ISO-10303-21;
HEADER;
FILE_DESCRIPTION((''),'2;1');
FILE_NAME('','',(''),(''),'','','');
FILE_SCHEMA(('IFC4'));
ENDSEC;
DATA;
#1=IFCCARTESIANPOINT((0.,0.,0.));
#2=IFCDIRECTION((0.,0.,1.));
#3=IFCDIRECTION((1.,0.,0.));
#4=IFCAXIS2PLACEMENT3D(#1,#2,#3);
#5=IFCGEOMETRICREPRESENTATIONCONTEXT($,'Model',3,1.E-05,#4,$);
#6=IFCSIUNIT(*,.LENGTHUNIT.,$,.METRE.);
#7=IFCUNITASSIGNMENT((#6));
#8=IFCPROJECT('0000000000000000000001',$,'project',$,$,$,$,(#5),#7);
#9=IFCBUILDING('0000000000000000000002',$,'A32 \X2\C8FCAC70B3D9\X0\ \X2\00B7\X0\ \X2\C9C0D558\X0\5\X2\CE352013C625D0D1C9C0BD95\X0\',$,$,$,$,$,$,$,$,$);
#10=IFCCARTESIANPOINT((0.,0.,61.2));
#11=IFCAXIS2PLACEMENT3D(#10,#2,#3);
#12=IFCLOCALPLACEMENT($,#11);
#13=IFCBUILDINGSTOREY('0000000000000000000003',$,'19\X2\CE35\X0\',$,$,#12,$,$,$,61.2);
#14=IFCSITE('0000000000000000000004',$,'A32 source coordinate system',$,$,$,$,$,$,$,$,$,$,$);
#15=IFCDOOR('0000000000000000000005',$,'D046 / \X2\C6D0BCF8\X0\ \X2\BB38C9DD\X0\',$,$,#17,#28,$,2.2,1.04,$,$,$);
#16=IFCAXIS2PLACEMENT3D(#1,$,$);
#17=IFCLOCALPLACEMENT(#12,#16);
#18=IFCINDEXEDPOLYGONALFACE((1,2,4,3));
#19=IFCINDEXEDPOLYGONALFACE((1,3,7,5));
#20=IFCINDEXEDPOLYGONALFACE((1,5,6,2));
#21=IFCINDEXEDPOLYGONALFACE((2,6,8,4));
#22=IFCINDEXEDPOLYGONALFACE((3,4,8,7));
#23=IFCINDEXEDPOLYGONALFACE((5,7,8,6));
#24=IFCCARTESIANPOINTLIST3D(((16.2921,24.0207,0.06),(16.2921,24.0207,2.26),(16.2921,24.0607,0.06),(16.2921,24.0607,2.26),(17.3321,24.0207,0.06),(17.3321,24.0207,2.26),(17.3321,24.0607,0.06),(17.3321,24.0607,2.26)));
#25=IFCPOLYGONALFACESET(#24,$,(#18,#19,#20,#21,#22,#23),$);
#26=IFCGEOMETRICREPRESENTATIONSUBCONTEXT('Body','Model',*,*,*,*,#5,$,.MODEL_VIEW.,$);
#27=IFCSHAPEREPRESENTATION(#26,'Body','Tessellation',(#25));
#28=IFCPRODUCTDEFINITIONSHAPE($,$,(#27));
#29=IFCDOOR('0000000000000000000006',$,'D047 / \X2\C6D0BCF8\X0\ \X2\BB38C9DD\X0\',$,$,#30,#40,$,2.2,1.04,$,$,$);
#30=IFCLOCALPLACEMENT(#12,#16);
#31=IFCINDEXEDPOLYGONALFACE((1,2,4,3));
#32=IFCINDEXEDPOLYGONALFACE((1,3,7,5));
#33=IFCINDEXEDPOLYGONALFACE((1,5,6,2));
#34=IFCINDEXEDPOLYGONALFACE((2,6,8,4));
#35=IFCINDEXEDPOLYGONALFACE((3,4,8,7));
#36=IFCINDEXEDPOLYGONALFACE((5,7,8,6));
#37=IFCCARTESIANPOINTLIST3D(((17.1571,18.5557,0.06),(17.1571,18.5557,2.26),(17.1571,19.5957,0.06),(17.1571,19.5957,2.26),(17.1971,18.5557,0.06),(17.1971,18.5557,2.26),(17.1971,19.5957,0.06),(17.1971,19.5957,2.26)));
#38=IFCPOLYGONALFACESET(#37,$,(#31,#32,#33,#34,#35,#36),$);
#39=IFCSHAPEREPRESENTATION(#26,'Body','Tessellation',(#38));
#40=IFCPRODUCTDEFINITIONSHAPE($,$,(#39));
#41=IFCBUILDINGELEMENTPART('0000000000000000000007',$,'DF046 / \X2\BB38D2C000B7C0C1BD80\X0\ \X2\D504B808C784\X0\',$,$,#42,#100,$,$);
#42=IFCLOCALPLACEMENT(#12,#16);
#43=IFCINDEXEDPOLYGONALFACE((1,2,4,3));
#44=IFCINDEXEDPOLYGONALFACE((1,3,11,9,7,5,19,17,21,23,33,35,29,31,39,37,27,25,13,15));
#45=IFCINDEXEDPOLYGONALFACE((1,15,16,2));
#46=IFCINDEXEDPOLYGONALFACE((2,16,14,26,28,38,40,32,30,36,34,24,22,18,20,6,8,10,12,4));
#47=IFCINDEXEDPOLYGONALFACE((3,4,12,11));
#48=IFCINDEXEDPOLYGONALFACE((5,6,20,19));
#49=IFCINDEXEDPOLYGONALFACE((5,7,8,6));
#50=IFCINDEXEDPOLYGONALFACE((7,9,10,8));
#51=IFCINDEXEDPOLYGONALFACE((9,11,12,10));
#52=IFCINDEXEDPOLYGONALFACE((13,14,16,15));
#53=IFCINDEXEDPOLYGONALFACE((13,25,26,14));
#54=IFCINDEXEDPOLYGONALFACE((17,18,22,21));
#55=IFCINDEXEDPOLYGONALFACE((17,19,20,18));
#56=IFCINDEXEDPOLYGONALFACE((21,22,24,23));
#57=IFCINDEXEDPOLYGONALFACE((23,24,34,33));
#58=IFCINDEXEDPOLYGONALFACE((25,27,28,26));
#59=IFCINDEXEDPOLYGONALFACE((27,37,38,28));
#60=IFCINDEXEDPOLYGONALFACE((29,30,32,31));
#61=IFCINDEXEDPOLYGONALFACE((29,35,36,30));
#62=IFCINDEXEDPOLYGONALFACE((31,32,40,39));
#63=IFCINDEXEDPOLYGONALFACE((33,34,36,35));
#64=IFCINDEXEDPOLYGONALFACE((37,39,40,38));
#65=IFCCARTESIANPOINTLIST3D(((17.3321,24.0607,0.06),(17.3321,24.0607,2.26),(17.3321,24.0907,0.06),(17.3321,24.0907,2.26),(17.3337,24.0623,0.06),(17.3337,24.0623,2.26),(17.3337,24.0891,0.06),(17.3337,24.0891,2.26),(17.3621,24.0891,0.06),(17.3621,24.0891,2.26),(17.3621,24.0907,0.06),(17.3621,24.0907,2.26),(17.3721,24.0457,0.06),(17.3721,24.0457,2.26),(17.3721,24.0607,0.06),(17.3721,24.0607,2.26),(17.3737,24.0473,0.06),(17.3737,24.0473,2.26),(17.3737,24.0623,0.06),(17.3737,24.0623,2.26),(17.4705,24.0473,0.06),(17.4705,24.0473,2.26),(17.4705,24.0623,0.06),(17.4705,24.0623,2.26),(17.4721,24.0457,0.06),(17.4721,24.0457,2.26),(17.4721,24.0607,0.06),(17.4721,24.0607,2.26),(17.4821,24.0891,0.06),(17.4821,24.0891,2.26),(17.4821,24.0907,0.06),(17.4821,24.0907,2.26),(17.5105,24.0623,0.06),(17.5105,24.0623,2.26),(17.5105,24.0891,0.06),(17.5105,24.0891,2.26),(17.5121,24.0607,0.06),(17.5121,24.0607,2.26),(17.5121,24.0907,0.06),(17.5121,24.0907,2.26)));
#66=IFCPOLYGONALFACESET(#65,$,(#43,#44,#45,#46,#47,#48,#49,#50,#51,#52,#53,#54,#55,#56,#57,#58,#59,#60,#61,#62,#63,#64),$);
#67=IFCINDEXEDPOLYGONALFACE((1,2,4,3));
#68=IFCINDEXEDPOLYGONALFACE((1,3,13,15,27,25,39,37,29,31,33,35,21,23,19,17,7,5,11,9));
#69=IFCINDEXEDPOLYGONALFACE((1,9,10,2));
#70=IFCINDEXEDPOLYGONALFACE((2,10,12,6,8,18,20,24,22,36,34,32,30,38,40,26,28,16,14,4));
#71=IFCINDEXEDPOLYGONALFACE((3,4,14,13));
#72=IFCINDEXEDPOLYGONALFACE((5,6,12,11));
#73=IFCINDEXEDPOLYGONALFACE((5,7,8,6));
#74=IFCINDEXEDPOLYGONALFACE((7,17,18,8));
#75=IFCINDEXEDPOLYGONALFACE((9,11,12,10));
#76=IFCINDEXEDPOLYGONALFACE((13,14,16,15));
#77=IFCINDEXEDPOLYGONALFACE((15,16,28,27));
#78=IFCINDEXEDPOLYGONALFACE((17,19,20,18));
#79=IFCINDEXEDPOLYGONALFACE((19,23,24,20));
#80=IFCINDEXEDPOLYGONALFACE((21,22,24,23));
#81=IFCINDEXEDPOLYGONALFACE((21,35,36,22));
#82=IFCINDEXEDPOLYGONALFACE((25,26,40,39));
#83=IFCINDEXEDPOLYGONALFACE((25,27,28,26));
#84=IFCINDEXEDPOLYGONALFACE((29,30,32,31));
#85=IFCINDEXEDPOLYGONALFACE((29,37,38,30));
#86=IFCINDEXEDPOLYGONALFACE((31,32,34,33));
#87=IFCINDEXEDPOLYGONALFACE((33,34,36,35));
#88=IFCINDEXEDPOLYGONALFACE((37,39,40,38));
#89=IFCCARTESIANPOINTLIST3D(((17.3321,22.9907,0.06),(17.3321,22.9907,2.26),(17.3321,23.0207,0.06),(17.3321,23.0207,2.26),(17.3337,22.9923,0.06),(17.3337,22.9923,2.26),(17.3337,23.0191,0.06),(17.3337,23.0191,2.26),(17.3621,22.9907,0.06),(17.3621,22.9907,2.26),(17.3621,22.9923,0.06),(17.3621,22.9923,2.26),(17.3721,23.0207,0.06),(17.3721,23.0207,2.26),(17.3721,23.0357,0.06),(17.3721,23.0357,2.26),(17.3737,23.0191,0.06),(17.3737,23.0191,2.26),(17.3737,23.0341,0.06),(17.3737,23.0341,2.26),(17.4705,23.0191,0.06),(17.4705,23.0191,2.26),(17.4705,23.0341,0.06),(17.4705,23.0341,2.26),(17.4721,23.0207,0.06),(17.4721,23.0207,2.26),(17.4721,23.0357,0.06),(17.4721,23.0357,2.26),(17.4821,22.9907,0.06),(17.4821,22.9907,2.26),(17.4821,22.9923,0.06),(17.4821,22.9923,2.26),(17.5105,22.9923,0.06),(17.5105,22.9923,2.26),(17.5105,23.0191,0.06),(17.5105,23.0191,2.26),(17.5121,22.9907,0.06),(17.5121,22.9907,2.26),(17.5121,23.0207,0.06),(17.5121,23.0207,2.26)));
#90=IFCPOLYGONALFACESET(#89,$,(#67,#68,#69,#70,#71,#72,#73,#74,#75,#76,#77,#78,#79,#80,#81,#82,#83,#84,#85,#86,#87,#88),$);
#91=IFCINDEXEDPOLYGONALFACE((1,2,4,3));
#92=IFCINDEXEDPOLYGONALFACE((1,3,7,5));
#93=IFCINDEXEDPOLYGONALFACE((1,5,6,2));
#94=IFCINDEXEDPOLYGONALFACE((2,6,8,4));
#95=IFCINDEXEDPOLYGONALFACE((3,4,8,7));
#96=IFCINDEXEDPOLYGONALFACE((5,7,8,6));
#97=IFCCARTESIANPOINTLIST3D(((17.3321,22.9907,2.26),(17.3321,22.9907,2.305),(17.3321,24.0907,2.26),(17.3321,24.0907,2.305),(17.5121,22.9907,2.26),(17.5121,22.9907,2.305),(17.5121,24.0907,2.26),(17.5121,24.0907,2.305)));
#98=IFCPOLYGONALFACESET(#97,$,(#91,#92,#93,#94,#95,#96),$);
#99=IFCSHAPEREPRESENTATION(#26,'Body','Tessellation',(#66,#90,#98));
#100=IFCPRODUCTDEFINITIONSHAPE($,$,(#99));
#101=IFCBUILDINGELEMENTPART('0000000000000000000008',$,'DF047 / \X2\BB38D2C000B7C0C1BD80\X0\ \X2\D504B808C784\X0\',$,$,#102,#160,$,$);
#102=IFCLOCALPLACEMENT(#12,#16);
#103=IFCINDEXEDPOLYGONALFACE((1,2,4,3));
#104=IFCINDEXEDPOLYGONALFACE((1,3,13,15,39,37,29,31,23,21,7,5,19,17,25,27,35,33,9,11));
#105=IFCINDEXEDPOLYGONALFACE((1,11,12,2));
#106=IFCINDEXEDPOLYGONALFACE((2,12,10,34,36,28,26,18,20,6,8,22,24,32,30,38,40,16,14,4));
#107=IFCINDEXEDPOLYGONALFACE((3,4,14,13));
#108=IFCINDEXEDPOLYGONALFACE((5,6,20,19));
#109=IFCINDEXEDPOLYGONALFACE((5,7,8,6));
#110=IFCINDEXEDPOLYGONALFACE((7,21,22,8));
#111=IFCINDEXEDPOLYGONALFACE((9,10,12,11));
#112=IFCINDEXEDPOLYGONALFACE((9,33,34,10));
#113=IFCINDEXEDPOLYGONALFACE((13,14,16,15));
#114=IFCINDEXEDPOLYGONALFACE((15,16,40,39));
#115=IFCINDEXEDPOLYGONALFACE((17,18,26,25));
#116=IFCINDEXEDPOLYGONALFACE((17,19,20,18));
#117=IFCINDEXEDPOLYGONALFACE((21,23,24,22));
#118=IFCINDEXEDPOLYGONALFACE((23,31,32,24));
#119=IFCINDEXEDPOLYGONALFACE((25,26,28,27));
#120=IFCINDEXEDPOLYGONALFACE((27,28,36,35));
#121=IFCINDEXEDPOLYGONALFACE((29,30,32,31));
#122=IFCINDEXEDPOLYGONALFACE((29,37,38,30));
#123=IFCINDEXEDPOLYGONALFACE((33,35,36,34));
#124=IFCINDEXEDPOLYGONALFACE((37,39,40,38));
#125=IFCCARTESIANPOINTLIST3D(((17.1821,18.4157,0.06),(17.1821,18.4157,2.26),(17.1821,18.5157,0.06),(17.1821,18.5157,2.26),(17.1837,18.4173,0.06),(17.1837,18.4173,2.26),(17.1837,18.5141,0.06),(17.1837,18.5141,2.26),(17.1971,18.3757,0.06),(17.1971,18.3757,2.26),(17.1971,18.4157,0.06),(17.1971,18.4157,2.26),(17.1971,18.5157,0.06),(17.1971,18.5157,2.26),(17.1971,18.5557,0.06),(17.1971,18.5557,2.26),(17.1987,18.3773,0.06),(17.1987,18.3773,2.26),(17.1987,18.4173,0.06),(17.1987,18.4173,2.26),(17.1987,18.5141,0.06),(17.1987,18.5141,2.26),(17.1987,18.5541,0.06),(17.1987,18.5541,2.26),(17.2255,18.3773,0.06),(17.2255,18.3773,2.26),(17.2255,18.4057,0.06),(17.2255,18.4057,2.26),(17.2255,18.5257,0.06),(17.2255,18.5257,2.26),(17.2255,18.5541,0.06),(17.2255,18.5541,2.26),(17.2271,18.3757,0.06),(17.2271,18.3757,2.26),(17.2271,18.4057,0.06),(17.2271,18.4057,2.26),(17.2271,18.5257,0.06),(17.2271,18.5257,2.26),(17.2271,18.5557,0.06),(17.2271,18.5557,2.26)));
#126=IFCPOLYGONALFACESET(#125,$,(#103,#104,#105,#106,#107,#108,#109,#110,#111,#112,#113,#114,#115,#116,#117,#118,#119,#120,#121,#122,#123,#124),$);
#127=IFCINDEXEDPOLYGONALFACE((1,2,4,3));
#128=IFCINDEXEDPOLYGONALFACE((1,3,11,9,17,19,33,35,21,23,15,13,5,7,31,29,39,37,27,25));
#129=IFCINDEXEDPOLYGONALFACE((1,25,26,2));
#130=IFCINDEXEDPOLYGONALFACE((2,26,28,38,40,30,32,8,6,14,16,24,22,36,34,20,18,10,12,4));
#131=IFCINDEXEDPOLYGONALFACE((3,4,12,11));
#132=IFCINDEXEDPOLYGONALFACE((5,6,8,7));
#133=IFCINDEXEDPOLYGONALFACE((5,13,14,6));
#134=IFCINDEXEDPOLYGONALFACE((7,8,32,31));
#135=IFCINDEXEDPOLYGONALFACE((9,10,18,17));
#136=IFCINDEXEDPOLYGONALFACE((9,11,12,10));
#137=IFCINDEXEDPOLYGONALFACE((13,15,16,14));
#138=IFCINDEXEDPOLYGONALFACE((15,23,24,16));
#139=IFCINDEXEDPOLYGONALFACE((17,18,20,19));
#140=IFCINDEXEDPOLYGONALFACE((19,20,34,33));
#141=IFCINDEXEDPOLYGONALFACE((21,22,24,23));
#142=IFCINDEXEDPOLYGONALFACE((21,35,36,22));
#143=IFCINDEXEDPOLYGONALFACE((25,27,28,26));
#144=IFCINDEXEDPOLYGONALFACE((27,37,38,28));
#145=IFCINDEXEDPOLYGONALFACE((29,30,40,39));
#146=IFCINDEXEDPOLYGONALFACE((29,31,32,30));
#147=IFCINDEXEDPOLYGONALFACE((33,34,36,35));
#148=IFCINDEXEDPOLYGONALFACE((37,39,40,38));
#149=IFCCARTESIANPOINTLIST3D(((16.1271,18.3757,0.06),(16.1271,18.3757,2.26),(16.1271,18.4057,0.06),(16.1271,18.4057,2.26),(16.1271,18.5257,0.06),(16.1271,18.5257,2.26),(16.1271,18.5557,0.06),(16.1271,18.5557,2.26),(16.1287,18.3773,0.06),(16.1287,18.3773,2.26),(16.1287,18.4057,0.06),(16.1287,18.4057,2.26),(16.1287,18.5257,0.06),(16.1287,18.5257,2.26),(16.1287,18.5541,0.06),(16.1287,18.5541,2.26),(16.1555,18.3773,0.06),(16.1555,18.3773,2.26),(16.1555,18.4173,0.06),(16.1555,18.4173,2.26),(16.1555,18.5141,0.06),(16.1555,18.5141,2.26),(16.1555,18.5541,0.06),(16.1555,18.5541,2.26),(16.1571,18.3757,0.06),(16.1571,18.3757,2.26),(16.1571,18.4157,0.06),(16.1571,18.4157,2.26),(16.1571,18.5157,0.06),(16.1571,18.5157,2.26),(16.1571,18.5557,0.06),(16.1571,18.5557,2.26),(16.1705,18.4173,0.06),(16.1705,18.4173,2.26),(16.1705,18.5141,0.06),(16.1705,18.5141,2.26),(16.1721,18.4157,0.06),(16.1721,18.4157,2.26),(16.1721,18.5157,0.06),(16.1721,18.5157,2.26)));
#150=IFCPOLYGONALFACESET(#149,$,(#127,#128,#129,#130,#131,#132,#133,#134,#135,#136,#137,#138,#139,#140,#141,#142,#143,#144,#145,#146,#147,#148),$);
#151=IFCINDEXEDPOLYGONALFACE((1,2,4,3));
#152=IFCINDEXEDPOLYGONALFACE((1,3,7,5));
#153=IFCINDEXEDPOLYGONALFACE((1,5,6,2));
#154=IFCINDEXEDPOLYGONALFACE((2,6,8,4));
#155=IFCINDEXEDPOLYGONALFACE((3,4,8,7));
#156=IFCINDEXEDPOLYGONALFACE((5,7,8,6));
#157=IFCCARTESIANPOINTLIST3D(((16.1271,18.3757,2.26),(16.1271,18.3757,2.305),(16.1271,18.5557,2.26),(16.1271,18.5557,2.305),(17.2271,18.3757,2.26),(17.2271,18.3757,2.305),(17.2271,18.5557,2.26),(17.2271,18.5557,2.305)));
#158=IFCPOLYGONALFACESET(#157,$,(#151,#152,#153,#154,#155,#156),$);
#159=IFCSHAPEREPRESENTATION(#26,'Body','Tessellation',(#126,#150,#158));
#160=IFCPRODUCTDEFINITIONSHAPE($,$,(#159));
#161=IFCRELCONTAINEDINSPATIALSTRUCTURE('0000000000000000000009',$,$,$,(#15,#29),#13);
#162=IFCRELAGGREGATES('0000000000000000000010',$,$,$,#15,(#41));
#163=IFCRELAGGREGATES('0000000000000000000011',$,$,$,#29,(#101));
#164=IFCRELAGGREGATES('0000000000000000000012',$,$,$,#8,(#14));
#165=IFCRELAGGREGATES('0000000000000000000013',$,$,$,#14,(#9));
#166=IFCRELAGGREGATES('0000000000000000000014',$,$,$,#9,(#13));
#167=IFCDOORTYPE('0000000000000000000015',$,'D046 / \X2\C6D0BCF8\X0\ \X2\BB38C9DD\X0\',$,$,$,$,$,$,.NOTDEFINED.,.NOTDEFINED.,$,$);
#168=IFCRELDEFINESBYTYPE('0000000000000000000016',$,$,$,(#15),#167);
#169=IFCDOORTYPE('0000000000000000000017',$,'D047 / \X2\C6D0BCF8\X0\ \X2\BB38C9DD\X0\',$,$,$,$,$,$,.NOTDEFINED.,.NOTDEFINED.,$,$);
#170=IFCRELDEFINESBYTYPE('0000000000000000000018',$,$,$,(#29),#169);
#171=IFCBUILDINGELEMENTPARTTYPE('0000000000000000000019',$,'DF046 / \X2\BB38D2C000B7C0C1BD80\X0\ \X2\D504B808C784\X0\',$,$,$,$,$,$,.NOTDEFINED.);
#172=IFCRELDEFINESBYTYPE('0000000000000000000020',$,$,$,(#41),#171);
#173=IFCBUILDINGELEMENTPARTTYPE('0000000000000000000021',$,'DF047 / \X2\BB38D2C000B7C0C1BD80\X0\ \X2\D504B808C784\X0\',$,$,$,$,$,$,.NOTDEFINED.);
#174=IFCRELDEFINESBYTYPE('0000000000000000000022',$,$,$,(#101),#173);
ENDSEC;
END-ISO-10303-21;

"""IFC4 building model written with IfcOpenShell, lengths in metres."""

from ifc_helpers import new_model, si_unit, frame, origin, origin_with_axes, place, context, subcontext, project, spatial, polyline, outline, extrude, source, transform, mapped, type_object, type_shapes, element, aggregate, save


model = new_model("IFC4")

# Units and contexts
model_context = context("Model", 3, precision=1e-05, world=origin_with_axes())
body_context = subcontext(model_context, "Body", "Model", "MODEL_VIEW")
ifc_project = project(units=[si_unit("LENGTHUNIT", "METRE")], contexts=[model_context])

# Site, building, storey
storey_placement = place(None, frame((0.0, 0.0, 61.2), z_axis=(0.0, 0.0, 1.0), x_axis=(1.0, 0.0, 0.0)))
site = spatial("IfcSite", under=ifc_project, Name="A32 source coordinate system")
building = spatial("IfcBuilding", under=site, Name="A32 주거동 · 지하5층–옥탑지붕")
storey = spatial("IfcBuildingStorey", under=building, at=storey_placement, Name="19층", Elevation=61.2)

# Doors
door_type_1 = type_object("IfcDoorType", Name="D046 / 원본 문짝", OperationType="NOTDEFINED", PredefinedType="NOTDEFINED")
shared_shape_1 = source(origin(), body_context, "Body", "SweptSolid", [
    extrude(outline(polyline([(17.3321, 24.0607), (17.3321, 24.0207), (16.2921, 24.0207), (16.2921, 24.0607), (17.3321, 24.0607)])), frame((0.0, 0.0, 0.06)), (0.0, 0.0, 1.0), 2.2),
])
type_shapes(door_type_1, [shared_shape_1])
door_1_placement = place(storey_placement, origin_with_axes())
door_1 = element("IfcDoor", 1, at=door_1_placement, inside=storey, type_object=door_type_1, Name="D046 / 원본 문짝", OverallHeight=2.2, OverallWidth=1.04, context=body_context, shape_type="MappedRepresentation", body=[
    mapped(shared_shape_1, transform((0.0, 0.0, 0.0), scale=1.0)),
])
door_type_2 = type_object("IfcDoorType", Name="D047 / 원본 문짝", OperationType="NOTDEFINED", PredefinedType="NOTDEFINED")
shared_shape_2 = source(origin(), body_context, "Body", "SweptSolid", [
    extrude(outline(polyline([(17.1971, 18.5557), (17.1571, 18.5557), (17.1571, 19.5957), (17.1971, 19.5957), (17.1971, 18.5557)])), frame((0.0, 0.0, 0.06)), (0.0, 0.0, 1.0), 2.2),
])
type_shapes(door_type_2, [shared_shape_2])
door_2_placement = place(storey_placement, origin_with_axes())
door_2 = element("IfcDoor", 2, at=door_2_placement, inside=storey, type_object=door_type_2, Name="D047 / 원본 문짝", OverallHeight=2.2, OverallWidth=1.04, context=body_context, shape_type="MappedRepresentation", body=[
    mapped(shared_shape_2, transform((0.0, 0.0, 0.0), scale=1.0)),
])

# Building element parts
building_element_part_type_1 = type_object("IfcBuildingElementPartType", Name="DF046 / 문틀·상부 프레임", PredefinedType="NOTDEFINED")
shared_shape_3 = source(origin(), body_context, "Body", "SweptSolid", [
    extrude(outline(polyline([(17.3337, 24.0891), (17.3337, 24.0623), (17.3737, 24.0623), (17.3737, 24.0473), (17.4705, 24.0473), (17.4705, 24.0623), (17.5105, 24.0623), (17.5105, 24.0891), (17.4821, 24.0891), (17.4821, 24.0907), (17.5121, 24.0907), (17.5121, 24.0607), (17.4721, 24.0607), (17.4721, 24.0457), (17.3721, 24.0457), (17.3721, 24.0607), (17.3321, 24.0607), (17.3321, 24.0907), (17.3621, 24.0907), (17.3621, 24.0891), (17.3337, 24.0891)])), frame((0.0, 0.0, 0.06)), (0.0, 0.0, 1.0), 2.2),
    extrude(outline(polyline([(17.3621, 22.9907), (17.3321, 22.9907), (17.3321, 23.0207), (17.3721, 23.0207), (17.3721, 23.0357), (17.4721, 23.0357), (17.4721, 23.0207), (17.5121, 23.0207), (17.5121, 22.9907), (17.4821, 22.9907), (17.4821, 22.9923), (17.5105, 22.9923), (17.5105, 23.0191), (17.4705, 23.0191), (17.4705, 23.0341), (17.3737, 23.0341), (17.3737, 23.0191), (17.3337, 23.0191), (17.3337, 22.9923), (17.3621, 22.9923), (17.3621, 22.9907)])), frame((0.0, 0.0, 0.06)), (0.0, 0.0, 1.0), 2.2),
    extrude(outline(polyline([(17.3321, 22.9907), (17.3321, 24.0907), (17.5121, 24.0907), (17.5121, 22.9907), (17.3321, 22.9907)])), frame((0.0, 0.0, 2.26)), (0.0, 0.0, 1.0), 0.045),
])
type_shapes(building_element_part_type_1, [shared_shape_3])
building_element_part_1_placement = place(door_1_placement, origin_with_axes())
building_element_part_1 = element("IfcBuildingElementPart", 3, at=building_element_part_1_placement, type_object=building_element_part_type_1, Name="DF046 / 문틀·상부 프레임", context=body_context, shape_type="MappedRepresentation", body=[
    mapped(shared_shape_3, transform((0.0, 0.0, 0.0), scale=1.0)),
])
aggregate(door_1, [building_element_part_1])
building_element_part_type_2 = type_object("IfcBuildingElementPartType", Name="DF047 / 문틀·상부 프레임", PredefinedType="NOTDEFINED")
shared_shape_4 = source(origin(), body_context, "Body", "SweptSolid", [
    extrude(outline(polyline([(17.2255, 18.5541), (17.1987, 18.5541), (17.1987, 18.5141), (17.1837, 18.5141), (17.1837, 18.4173), (17.1987, 18.4173), (17.1987, 18.3773), (17.2255, 18.3773), (17.2255, 18.4057), (17.2271, 18.4057), (17.2271, 18.3757), (17.1971, 18.3757), (17.1971, 18.4157), (17.1821, 18.4157), (17.1821, 18.5157), (17.1971, 18.5157), (17.1971, 18.5557), (17.2271, 18.5557), (17.2271, 18.5257), (17.2255, 18.5257), (17.2255, 18.5541)])), frame((0.0, 0.0, 0.06)), (0.0, 0.0, 1.0), 2.2),
    extrude(outline(polyline([(16.1271, 18.5257), (16.1271, 18.5557), (16.1571, 18.5557), (16.1571, 18.5157), (16.1721, 18.5157), (16.1721, 18.4157), (16.1571, 18.4157), (16.1571, 18.3757), (16.1271, 18.3757), (16.1271, 18.4057), (16.1287, 18.4057), (16.1287, 18.3773), (16.1555, 18.3773), (16.1555, 18.4173), (16.1705, 18.4173), (16.1705, 18.5141), (16.1555, 18.5141), (16.1555, 18.5541), (16.1287, 18.5541), (16.1287, 18.5257), (16.1271, 18.5257)])), frame((0.0, 0.0, 0.06)), (0.0, 0.0, 1.0), 2.2),
    extrude(outline(polyline([(16.1271, 18.3757), (16.1271, 18.5557), (17.2271, 18.5557), (17.2271, 18.3757), (16.1271, 18.3757)])), frame((0.0, 0.0, 2.26)), (0.0, 0.0, 1.0), 0.045),
])
type_shapes(building_element_part_type_2, [shared_shape_4])
building_element_part_2_placement = place(door_2_placement, origin_with_axes())
building_element_part_2 = element("IfcBuildingElementPart", 4, at=building_element_part_2_placement, type_object=building_element_part_type_2, Name="DF047 / 문틀·상부 프레임", context=body_context, shape_type="MappedRepresentation", body=[
    mapped(shared_shape_4, transform((0.0, 0.0, 0.0), scale=1.0)),
])
aggregate(door_2, [building_element_part_2])

save(model, "model.ifc")
